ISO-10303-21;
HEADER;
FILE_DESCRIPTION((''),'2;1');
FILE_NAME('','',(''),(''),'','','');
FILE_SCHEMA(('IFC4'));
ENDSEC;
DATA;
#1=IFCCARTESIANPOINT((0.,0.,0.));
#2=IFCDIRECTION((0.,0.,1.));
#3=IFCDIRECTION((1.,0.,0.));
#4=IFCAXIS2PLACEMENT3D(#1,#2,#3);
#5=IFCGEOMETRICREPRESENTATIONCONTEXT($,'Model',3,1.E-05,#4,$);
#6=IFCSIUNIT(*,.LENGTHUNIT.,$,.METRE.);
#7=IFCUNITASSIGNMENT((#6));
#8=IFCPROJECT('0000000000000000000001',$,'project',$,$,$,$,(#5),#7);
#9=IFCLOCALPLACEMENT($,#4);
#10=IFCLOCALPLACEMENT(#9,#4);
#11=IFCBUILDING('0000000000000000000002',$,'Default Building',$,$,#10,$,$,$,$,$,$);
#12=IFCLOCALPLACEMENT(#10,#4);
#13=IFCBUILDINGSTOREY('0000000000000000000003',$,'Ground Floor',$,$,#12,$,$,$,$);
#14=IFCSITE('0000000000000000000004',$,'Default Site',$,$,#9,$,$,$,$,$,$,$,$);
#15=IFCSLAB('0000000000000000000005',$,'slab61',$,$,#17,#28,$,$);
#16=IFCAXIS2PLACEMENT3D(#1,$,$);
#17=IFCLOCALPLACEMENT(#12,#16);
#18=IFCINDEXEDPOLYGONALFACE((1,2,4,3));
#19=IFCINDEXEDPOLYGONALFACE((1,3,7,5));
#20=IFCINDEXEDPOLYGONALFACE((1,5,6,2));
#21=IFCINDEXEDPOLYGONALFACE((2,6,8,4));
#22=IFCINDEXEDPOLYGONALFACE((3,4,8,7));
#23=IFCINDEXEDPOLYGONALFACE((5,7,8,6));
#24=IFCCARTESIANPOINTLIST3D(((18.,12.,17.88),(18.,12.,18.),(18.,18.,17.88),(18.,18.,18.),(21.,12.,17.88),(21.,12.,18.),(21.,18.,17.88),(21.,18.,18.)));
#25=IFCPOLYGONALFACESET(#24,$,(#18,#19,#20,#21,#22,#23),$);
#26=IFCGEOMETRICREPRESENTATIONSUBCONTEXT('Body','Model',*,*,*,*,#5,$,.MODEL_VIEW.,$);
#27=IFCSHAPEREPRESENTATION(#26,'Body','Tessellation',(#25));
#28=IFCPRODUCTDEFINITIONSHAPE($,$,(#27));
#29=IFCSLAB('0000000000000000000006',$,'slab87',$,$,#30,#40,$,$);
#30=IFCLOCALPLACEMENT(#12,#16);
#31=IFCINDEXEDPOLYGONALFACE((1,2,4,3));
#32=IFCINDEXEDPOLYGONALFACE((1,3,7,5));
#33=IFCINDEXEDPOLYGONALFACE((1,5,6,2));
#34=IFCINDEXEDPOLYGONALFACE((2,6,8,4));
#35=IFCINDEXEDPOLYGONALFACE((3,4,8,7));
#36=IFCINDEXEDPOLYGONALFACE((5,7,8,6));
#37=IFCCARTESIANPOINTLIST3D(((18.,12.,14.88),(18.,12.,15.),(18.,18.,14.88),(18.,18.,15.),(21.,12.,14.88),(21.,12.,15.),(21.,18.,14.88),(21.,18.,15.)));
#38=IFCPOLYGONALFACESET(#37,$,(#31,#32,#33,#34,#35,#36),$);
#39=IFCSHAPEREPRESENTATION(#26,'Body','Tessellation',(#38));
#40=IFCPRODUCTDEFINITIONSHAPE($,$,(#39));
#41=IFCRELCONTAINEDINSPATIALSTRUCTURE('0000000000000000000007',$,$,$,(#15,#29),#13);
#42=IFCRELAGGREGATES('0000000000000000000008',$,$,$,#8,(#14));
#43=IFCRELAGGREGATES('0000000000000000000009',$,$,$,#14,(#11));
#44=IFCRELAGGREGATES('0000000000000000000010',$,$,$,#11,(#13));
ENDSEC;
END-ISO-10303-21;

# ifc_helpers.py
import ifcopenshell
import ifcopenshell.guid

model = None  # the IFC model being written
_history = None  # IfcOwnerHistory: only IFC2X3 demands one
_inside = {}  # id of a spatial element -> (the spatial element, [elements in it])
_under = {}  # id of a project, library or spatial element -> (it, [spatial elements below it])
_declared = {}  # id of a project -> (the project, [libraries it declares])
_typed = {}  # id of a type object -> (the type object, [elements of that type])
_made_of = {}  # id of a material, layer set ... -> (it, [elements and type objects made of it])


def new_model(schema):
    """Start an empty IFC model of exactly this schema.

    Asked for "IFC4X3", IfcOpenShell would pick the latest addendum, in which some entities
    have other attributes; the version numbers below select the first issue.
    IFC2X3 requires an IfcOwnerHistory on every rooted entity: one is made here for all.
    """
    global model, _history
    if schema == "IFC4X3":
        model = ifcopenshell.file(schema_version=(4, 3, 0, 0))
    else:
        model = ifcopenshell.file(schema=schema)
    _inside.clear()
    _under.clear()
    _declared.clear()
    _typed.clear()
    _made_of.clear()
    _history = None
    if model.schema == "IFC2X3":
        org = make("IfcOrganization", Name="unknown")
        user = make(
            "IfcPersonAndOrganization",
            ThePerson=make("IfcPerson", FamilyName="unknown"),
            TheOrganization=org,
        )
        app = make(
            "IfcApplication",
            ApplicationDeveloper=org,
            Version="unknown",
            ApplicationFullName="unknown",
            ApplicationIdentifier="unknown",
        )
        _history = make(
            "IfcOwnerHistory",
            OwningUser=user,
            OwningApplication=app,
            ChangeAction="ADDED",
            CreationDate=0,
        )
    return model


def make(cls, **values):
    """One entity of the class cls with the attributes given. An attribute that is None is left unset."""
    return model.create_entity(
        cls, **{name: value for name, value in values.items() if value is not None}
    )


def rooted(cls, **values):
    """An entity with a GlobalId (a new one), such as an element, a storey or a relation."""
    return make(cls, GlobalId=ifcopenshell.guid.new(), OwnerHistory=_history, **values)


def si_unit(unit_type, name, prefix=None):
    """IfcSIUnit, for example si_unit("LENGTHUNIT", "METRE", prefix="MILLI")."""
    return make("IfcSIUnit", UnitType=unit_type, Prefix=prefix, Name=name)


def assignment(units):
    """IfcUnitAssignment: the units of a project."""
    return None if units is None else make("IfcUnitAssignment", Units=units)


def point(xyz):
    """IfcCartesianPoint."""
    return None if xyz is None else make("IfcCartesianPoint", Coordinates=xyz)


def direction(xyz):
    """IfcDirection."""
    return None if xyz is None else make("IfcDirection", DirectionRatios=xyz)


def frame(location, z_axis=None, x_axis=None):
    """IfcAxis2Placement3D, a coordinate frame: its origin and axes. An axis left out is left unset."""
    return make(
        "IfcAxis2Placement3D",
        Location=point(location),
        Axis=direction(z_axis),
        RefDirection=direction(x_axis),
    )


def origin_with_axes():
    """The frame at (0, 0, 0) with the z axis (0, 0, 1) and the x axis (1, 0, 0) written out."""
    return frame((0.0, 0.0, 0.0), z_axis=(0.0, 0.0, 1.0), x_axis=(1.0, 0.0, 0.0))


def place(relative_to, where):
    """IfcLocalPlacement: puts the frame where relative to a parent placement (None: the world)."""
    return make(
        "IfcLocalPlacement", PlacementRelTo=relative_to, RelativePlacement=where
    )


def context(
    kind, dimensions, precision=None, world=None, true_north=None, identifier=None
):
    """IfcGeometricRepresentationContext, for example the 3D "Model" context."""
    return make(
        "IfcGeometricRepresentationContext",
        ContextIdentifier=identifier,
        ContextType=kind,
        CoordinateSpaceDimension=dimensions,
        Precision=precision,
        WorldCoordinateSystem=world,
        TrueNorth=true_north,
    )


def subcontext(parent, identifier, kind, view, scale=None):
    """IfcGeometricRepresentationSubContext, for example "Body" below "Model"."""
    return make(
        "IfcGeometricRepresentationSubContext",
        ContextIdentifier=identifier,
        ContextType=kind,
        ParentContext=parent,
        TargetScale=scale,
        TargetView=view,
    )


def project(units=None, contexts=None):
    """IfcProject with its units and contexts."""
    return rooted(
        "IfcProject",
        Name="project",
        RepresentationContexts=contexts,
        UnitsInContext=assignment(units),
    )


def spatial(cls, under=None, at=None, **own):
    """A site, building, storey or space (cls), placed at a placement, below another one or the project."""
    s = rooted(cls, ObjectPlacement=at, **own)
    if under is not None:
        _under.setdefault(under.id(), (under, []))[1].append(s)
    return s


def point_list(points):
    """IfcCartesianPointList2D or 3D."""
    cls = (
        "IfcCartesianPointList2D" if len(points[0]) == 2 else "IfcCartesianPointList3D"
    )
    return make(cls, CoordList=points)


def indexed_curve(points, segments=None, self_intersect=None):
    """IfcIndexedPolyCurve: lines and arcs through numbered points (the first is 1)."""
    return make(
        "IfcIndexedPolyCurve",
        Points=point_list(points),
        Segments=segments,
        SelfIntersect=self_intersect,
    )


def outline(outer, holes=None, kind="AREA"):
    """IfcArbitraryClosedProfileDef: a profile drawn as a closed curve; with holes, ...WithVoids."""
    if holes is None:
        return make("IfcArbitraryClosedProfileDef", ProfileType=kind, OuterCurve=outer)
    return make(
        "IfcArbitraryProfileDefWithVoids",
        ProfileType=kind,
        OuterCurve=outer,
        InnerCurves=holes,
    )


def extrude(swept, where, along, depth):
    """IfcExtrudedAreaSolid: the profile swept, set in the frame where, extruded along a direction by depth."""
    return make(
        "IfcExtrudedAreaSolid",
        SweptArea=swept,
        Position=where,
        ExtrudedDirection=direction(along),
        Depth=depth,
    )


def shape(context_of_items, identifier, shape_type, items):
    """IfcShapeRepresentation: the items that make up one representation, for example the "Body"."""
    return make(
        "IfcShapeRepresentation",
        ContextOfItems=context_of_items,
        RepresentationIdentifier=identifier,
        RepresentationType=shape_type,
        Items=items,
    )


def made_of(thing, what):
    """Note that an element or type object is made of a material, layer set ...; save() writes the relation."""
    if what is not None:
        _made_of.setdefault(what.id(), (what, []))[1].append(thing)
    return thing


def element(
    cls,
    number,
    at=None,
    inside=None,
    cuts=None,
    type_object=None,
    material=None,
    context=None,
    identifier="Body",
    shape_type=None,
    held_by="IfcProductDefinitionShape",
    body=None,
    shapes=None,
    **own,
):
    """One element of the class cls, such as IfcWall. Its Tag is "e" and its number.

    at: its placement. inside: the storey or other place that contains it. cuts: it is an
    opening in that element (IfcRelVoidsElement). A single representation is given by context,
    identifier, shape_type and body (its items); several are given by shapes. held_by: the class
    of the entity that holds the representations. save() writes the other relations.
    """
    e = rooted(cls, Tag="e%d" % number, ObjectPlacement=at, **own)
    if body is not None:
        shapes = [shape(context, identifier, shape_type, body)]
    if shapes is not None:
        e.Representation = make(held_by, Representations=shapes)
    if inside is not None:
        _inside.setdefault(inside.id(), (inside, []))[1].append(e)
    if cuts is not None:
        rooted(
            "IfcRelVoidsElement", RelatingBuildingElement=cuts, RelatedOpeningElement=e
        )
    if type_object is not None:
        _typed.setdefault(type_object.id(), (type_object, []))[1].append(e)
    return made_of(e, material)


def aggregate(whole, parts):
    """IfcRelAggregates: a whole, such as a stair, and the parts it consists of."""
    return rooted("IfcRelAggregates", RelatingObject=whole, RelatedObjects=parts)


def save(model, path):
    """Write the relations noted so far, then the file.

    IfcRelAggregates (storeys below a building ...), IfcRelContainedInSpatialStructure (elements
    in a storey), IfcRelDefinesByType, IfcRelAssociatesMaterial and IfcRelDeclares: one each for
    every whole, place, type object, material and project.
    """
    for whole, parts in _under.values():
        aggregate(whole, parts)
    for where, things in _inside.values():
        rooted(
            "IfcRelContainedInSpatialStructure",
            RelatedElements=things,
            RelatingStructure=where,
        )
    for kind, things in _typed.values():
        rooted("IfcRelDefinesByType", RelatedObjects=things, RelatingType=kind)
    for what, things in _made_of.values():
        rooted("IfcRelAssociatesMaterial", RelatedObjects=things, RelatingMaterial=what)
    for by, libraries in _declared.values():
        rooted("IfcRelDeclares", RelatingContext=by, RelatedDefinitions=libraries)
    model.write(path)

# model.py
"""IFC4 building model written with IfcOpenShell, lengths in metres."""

from ifc_helpers import new_model, si_unit, frame, origin_with_axes, place, context, subcontext, project, spatial, indexed_curve, outline, extrude, element, save


model = new_model("IFC4")

# Units and contexts
model_context = context("Model", 3, precision=1e-05, world=origin_with_axes())
body_context = subcontext(model_context, "Body", "Model", "MODEL_VIEW")
ifc_project = project(units=[si_unit("LENGTHUNIT", "METRE")], contexts=[model_context])

# Site, building, storey
site_placement = place(None, origin_with_axes())
site = spatial("IfcSite", under=ifc_project, at=site_placement, Name="Default Site")
building_placement = place(site_placement, origin_with_axes())
building = spatial("IfcBuilding", under=site, at=building_placement, Name="Default Building")
storey_placement = place(building_placement, origin_with_axes())
storey = spatial("IfcBuildingStorey", under=building, at=storey_placement, Name="Ground Floor")

# Slabs
for number, where, z_axis, x_axis, name in (
    (1, (18.0, 12.0, 17.88), (0.0, 0.0, 1.0), (1.0, 0.0, 0.0), "slab61"),
    (2, (18.0, 12.0, 14.88), (0.0, 0.0, 1.0), (1.0, 0.0, 0.0), "slab87"),
):
    element("IfcSlab", number, at=place(storey_placement, frame(where, z_axis=z_axis, x_axis=x_axis)), inside=storey, Name=name, context=body_context, shape_type="SweptSolid", body=[
        extrude(outline(indexed_curve([(0.0, 0.0), (0.0, 6.0), (3.0, 6.0), (3.0, 0.0), (0.0, 0.0)], self_intersect=False)), origin_with_axes(), (0.0, 0.0, 1.0), 0.12),
    ])

save(model, "model.ifc")
